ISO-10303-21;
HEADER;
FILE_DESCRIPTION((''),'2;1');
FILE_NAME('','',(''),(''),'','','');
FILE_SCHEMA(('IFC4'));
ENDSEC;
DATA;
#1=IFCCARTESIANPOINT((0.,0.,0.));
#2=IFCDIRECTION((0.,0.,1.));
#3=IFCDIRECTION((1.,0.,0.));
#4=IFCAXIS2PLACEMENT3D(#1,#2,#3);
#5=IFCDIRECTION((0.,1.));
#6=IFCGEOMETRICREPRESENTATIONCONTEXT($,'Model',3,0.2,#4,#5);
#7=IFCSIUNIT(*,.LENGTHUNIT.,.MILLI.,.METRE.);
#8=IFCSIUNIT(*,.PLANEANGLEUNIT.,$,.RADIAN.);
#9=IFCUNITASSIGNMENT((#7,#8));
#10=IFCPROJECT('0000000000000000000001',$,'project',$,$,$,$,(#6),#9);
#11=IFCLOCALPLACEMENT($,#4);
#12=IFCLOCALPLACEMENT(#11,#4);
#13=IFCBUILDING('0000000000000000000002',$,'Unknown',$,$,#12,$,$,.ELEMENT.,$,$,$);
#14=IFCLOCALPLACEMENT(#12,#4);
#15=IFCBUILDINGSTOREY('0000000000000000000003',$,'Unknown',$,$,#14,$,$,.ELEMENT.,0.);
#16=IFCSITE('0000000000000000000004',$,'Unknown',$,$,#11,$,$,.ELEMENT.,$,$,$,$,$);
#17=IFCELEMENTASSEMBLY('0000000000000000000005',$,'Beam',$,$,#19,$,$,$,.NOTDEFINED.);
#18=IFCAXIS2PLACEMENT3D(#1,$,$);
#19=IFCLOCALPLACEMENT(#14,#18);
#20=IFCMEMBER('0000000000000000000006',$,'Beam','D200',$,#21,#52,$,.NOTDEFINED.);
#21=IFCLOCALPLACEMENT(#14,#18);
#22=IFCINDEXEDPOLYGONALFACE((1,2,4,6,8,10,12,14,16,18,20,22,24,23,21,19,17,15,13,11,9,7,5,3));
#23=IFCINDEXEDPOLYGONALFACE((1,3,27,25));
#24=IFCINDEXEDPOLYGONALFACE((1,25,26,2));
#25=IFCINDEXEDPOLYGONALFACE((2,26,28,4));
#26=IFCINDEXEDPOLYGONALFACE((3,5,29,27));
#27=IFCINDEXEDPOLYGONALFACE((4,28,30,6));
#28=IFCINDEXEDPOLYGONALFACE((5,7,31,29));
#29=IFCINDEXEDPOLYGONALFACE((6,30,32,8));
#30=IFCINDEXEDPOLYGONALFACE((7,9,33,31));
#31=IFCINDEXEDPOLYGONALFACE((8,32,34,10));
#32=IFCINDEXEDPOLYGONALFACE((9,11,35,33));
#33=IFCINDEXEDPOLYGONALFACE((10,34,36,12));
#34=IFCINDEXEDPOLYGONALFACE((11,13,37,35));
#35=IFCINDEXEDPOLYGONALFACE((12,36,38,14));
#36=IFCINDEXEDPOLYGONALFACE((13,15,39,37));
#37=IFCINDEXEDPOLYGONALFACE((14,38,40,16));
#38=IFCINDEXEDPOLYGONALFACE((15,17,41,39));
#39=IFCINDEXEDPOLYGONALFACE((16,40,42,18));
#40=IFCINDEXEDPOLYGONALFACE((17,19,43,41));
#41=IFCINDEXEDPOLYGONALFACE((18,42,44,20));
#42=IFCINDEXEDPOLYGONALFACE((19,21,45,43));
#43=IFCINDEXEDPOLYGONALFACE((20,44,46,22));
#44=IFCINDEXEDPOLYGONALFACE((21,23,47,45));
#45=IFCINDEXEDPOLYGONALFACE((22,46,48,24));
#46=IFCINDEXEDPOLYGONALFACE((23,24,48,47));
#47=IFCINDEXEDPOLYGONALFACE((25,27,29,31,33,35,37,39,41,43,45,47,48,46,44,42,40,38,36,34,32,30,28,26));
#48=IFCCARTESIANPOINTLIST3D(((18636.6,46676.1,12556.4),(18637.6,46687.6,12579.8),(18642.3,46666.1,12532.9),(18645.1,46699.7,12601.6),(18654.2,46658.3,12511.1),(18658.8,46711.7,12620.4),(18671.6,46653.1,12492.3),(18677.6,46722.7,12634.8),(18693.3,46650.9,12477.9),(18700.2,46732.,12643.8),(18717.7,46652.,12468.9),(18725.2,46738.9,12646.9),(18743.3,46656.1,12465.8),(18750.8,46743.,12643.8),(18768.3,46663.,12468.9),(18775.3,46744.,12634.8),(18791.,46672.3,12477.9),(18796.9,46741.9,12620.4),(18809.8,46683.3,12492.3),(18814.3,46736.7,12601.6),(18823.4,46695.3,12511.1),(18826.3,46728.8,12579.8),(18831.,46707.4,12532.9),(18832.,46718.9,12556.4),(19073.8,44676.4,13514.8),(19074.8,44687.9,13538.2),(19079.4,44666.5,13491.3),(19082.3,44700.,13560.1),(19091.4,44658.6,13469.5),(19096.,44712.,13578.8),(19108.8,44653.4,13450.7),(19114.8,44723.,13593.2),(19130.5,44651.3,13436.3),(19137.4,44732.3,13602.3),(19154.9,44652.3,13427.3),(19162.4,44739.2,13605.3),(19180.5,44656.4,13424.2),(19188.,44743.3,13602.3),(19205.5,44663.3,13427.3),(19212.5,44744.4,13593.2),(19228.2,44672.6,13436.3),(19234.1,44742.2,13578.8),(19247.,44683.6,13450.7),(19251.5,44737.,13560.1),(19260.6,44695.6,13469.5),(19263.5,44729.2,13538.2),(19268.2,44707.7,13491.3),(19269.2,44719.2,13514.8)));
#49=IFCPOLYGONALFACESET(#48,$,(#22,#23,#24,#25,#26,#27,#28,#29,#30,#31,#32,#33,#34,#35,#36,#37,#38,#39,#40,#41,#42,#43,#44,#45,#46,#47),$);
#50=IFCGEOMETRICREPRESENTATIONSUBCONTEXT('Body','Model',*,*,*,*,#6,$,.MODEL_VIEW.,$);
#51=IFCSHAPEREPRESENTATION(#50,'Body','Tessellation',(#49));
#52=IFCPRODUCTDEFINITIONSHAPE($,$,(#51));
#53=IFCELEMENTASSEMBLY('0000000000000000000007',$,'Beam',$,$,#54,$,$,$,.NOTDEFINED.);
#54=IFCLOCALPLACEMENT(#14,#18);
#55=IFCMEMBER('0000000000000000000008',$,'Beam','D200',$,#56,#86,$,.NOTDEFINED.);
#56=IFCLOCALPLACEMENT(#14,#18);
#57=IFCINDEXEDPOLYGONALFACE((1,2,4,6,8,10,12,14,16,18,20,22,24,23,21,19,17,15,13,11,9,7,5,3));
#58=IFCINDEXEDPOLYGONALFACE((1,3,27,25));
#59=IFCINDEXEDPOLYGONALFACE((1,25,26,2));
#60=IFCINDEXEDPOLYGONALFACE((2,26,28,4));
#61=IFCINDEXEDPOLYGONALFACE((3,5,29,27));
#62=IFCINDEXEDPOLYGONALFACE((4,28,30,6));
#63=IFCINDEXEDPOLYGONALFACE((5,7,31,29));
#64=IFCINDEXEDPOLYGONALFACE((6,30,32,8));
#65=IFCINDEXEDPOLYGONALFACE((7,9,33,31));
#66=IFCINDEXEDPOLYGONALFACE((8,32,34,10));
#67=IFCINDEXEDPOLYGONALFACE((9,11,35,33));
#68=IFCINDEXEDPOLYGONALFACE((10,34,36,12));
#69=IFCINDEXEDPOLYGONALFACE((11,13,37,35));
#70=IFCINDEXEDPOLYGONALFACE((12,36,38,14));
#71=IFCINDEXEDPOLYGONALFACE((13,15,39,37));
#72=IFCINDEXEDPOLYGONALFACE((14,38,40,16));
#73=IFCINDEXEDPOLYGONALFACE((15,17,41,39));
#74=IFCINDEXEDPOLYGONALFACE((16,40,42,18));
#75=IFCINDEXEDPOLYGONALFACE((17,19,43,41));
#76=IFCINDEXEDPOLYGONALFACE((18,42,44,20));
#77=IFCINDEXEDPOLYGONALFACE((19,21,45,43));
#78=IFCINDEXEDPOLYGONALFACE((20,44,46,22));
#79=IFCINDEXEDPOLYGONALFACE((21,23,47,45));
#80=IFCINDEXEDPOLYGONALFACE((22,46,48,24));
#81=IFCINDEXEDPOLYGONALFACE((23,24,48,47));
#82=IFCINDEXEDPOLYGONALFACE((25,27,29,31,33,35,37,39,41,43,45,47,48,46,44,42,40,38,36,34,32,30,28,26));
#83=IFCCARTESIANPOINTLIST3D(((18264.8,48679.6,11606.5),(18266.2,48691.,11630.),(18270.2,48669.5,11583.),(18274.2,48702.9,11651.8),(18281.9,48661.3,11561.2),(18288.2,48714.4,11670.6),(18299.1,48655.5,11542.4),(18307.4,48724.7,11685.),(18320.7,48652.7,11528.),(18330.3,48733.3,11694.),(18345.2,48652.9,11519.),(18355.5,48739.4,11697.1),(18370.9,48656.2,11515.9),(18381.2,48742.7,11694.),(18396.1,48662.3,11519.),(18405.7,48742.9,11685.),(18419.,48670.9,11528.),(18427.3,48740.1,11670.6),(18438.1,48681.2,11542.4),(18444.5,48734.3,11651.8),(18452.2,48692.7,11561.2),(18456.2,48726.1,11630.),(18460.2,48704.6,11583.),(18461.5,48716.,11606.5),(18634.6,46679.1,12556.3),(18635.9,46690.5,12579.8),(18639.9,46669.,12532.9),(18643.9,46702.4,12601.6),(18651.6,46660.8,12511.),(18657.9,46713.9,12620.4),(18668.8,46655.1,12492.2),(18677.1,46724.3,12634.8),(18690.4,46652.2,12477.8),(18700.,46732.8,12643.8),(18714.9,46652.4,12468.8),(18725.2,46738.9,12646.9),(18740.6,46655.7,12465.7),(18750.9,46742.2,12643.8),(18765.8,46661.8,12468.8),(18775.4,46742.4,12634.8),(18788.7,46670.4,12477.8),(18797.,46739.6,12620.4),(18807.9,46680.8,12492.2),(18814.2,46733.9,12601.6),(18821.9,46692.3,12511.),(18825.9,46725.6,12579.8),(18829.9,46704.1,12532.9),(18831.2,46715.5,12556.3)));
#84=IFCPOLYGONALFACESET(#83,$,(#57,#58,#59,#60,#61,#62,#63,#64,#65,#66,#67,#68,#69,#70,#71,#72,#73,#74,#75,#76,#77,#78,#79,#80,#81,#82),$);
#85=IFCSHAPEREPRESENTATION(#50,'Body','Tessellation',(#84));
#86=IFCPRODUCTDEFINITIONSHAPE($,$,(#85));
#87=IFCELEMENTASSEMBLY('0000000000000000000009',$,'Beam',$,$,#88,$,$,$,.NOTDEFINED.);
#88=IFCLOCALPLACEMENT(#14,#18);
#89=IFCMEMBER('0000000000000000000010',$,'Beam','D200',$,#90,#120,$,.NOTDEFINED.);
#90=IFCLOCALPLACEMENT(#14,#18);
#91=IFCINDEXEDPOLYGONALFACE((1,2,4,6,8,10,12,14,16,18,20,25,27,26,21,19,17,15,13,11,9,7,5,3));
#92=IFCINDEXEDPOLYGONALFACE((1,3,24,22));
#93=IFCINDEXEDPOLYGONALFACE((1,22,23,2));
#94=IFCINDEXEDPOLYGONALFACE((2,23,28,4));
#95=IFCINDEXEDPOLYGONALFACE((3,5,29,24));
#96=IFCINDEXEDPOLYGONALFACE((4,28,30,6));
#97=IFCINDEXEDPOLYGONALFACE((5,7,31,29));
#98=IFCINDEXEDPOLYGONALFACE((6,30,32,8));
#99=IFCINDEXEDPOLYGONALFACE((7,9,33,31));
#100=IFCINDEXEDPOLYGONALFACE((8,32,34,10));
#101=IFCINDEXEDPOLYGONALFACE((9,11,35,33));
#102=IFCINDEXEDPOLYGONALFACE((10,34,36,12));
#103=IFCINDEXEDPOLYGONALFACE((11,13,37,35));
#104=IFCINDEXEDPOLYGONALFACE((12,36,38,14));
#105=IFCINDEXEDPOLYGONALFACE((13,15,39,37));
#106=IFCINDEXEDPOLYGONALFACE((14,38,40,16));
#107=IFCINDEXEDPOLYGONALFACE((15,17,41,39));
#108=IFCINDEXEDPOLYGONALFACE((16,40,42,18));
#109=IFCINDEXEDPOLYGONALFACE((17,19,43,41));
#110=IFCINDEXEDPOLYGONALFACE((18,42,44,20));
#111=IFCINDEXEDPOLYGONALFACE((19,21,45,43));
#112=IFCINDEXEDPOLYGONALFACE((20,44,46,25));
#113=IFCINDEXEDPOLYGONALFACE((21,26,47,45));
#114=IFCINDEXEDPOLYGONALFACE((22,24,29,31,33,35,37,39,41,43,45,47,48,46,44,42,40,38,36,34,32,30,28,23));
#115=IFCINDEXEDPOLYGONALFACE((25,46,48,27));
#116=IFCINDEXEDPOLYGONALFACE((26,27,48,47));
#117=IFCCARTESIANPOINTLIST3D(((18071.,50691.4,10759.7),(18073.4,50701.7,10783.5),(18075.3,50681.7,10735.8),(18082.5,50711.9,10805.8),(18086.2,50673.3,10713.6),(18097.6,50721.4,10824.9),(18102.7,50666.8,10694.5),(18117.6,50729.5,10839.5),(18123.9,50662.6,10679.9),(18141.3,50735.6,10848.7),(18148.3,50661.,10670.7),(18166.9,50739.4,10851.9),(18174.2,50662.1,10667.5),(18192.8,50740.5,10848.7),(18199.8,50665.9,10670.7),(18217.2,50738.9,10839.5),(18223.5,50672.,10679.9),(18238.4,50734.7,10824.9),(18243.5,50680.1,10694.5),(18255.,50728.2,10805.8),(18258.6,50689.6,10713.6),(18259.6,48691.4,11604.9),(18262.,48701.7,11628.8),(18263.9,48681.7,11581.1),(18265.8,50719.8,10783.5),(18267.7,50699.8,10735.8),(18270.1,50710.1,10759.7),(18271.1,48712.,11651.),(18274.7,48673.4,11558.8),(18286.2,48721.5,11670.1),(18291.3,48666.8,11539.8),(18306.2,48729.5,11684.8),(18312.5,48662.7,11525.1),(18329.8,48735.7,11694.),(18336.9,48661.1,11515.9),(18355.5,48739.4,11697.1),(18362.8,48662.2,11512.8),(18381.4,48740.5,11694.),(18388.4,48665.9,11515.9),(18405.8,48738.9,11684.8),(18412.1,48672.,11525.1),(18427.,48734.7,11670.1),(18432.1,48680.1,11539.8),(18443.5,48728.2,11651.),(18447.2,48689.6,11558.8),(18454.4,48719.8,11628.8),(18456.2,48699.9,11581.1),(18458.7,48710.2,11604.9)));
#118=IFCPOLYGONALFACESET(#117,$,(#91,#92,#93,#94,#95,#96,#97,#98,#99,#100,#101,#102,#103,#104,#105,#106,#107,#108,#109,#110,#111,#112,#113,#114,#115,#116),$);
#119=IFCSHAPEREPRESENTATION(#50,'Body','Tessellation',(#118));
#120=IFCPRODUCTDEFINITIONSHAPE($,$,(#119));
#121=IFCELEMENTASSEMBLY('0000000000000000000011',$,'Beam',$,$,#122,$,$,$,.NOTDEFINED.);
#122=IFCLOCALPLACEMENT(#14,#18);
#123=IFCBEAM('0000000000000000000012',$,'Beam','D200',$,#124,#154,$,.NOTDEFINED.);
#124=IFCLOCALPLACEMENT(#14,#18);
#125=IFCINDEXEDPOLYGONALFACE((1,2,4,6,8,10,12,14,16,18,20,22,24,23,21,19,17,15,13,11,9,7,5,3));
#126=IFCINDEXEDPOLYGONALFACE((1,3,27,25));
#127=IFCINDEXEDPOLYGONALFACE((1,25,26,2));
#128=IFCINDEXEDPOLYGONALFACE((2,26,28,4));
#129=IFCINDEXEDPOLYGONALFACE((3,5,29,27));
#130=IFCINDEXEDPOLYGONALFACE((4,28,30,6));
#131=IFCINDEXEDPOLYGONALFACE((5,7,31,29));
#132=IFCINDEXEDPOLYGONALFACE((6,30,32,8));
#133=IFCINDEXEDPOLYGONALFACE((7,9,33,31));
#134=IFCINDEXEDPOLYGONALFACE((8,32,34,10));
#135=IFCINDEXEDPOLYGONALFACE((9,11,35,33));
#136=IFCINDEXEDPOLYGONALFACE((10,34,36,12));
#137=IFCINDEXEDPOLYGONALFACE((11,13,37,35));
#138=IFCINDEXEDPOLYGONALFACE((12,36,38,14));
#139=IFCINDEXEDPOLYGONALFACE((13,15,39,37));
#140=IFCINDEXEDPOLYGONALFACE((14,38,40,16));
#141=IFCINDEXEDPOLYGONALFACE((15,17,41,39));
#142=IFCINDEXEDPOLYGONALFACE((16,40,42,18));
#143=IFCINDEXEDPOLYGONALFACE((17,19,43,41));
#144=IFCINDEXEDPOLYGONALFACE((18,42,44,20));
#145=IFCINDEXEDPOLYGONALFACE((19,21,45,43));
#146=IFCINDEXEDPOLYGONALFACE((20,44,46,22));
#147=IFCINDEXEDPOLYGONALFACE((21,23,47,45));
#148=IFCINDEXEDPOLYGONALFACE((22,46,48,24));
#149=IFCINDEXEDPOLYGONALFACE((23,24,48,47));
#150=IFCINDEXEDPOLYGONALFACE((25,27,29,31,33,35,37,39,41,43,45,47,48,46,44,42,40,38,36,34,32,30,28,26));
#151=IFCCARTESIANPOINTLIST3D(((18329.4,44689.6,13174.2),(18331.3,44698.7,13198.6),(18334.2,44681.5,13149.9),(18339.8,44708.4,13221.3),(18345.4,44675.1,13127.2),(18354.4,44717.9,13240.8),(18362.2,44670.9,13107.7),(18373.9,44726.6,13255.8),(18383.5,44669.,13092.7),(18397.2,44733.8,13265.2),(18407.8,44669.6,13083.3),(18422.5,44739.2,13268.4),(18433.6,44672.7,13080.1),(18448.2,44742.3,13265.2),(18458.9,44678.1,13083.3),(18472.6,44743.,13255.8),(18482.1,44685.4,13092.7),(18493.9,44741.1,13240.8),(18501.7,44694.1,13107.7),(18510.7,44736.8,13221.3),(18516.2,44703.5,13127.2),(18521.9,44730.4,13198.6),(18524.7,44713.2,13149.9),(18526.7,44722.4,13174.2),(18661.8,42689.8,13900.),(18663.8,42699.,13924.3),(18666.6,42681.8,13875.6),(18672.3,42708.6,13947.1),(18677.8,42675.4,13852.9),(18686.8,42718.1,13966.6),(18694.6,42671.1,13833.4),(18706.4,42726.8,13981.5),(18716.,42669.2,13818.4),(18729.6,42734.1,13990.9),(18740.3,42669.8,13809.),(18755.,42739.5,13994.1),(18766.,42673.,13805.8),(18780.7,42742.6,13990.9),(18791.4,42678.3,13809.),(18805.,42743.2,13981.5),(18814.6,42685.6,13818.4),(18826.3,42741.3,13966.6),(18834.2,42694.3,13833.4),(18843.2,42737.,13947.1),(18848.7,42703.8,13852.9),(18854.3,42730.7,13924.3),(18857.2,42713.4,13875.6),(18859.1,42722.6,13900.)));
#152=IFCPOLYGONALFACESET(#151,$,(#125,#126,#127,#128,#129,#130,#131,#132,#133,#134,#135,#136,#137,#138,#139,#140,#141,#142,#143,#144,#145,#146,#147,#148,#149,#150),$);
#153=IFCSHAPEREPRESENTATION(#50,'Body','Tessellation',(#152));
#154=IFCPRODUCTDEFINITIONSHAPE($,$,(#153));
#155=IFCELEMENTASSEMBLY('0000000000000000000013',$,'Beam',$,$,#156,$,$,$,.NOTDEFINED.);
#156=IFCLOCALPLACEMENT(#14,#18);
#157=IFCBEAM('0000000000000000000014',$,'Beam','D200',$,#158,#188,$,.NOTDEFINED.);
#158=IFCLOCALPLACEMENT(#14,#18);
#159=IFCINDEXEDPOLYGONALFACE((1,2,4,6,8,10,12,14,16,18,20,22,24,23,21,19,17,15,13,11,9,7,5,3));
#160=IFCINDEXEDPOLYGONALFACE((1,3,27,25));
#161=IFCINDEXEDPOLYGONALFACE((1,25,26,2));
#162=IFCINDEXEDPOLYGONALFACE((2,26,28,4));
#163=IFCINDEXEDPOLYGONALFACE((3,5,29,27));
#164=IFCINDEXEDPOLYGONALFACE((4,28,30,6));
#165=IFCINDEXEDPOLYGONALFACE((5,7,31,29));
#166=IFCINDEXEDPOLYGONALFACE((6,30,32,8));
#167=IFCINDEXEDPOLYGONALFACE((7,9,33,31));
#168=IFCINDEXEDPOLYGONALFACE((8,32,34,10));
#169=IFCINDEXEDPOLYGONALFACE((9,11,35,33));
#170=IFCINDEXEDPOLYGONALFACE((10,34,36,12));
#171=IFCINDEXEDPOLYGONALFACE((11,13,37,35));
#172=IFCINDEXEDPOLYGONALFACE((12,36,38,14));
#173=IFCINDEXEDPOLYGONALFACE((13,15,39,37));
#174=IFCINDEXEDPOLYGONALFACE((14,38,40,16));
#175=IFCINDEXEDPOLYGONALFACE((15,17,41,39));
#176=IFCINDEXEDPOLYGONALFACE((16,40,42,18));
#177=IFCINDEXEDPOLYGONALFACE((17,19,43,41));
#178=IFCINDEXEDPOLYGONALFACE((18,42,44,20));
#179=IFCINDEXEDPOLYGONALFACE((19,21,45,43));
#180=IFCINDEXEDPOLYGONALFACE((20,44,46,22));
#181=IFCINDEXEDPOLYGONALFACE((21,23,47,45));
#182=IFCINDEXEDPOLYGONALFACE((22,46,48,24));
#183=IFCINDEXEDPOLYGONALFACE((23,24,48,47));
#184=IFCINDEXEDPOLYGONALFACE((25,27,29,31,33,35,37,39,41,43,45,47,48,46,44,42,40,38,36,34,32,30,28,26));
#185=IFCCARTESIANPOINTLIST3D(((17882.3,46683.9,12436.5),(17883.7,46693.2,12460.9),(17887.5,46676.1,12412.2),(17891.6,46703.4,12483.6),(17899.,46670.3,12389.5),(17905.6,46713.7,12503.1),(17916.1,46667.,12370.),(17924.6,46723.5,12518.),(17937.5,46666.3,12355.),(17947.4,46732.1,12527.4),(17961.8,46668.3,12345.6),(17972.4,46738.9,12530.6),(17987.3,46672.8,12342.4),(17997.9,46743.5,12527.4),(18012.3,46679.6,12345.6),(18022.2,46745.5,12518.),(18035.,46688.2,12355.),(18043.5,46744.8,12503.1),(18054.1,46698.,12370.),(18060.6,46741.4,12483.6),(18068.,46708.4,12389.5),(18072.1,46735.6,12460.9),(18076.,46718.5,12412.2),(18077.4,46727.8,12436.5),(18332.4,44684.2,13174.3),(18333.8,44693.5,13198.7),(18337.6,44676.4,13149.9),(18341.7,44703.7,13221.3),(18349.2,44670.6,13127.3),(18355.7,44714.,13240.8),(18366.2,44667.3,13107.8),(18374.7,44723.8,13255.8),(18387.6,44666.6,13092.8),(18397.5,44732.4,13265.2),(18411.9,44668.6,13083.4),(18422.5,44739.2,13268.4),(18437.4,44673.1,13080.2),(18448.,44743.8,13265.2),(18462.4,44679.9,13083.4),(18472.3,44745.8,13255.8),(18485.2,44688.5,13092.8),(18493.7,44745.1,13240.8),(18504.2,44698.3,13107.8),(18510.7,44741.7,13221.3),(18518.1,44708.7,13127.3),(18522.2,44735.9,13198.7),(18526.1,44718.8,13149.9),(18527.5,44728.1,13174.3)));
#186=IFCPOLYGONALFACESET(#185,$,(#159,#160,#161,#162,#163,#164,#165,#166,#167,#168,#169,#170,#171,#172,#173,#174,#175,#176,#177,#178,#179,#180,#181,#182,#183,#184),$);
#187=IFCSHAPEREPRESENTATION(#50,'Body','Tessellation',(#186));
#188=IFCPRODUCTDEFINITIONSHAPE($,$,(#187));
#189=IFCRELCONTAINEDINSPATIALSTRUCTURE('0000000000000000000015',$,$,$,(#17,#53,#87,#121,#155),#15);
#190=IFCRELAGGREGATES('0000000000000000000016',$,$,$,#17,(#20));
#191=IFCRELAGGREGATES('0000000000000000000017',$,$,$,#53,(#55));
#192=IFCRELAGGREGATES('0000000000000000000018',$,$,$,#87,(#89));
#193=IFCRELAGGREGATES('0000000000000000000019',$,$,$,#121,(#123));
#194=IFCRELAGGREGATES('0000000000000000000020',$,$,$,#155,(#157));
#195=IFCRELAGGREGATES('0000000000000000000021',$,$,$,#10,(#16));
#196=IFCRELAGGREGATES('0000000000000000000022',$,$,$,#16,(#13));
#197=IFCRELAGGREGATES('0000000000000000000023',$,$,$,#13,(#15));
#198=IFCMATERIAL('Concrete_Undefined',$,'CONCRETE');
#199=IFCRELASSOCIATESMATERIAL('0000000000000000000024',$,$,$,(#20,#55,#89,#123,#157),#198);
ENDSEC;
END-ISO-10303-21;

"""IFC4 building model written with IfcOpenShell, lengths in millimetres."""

from ifc_helpers import new_model, si_unit, direction, frame, origin_with_axes, place, context, subcontext, project, spatial, line, indexed_curve, outline, extrude, material, element, aggregate, save


model = new_model("IFC4")

# Units and contexts
model_context = context("Model", 3, precision=0.2, world=origin_with_axes(), true_north=direction((0.0, 1.0)))
body_context = subcontext(model_context, "Body", "Model", "MODEL_VIEW")
ifc_project = project(units=[si_unit("LENGTHUNIT", "METRE", prefix="MILLI"), si_unit("PLANEANGLEUNIT", "RADIAN")], contexts=[model_context])

# Site, building, storey
site_placement = place(None, origin_with_axes())
site = spatial("IfcSite", under=ifc_project, at=site_placement, Name="Unknown", CompositionType="ELEMENT")
building_placement = place(site_placement, origin_with_axes())
building = spatial("IfcBuilding", under=site, at=building_placement, Name="Unknown", CompositionType="ELEMENT")
storey_placement = place(building_placement, origin_with_axes())
storey = spatial("IfcBuildingStorey", under=building, at=storey_placement, Name="Unknown", CompositionType="ELEMENT", Elevation=0.0)

# Shared definitions
ifc_material = material(Name="Concrete_Undefined", Category="CONCRETE")

# Element assemblies, members
assembly_1_placement = place(storey_placement, frame((18734.3, 46697.5, 12556.4), z_axis=(-0.976924, -0.213586, 0.0), x_axis=(0.193433, -0.884744, 0.424042)))
assembly_1 = element("IfcElementAssembly", 1, at=assembly_1_placement, inside=storey, Name="Beam", PredefinedType="NOTDEFINED")
member_1_placement = place(assembly_1_placement, origin_with_axes())
member_1 = element("IfcMember", 2, at=member_1_placement, material=ifc_material, Name="Beam", Description="D200", PredefinedType="NOTDEFINED", context=body_context, shape_type="SolidModel", body=[
    extrude(outline(indexed_curve([(100.0, 0.0), (96.6, 25.9), (86.6, 50.0), (70.7, 70.7), (50.0, 86.6), (25.9, 96.6), (0.0, 100.0), (-25.9, 96.6), (-50.0, 86.6), (-70.7, 70.7), (-86.6, 50.0), (-96.6, 25.9), (-100.0, 0.0), (-96.6, -25.9), (-86.6, -50.0), (-70.7, -70.7), (-50.0, -86.6), (-25.9, -96.6), (0.0, -100.0), (25.9, -96.6), (50.0, -86.6), (70.7, -70.7), (86.6, -50.0), (96.6, -25.9)], segments=[line(1, 2, 3, 4, 5, 6, 7, 8, 9, 10, 11, 12, 13, 14, 15, 16, 17, 18, 19, 20, 21, 22, 23, 24, 1)])), frame((0.0, 0.0, 0.0), z_axis=(-1.0, 0.0, 0.0), x_axis=(0.0, 0.0, 1.0)), (0.0, 0.0, -1.0), 2260.2),
])
aggregate(assembly_1, [member_1])
assembly_2_placement = place(storey_placement, frame((18363.2, 48697.8, 11606.5), z_axis=(-0.983346, -0.181742, 0.0), x_axis=(0.164677, -0.891016, 0.423052)))
assembly_2 = element("IfcElementAssembly", 3, at=assembly_2_placement, inside=storey, Name="Beam", PredefinedType="NOTDEFINED")
member_2_placement = place(assembly_2_placement, origin_with_axes())
member_2 = element("IfcMember", 4, at=member_2_placement, material=ifc_material, Name="Beam", Description="D200", PredefinedType="NOTDEFINED", context=body_context, shape_type="SolidModel", body=[
    extrude(outline(indexed_curve([(100.0, 0.0), (96.6, 25.9), (86.6, 50.0), (70.7, 70.7), (50.0, 86.6), (25.9, 96.6), (0.0, 100.0), (-25.9, 96.6), (-50.0, 86.6), (-70.7, 70.7), (-86.6, 50.0), (-96.6, 25.9), (-100.0, 0.0), (-96.6, -25.9), (-86.6, -50.0), (-70.7, -70.7), (-50.0, -86.6), (-25.9, -96.6), (0.0, -100.0), (25.9, -96.6), (50.0, -86.6), (70.7, -70.7), (86.6, -50.0), (96.6, -25.9)], segments=[line(1, 2, 3, 4, 5, 6, 7, 8, 9, 10, 11, 12, 13, 14, 15, 16, 17, 18, 19, 20, 21, 22, 23, 24, 1)])), frame((0.0, 0.0, 0.0), z_axis=(-1.0, 0.0, 0.0), x_axis=(0.0, 0.0, 1.0)), (0.0, 0.0, -1.0), 2245.2),
])
aggregate(assembly_2, [member_2])
assembly_3_placement = place(storey_placement, frame((18170.6, 50700.8, 10759.7), z_axis=(-0.995584, -0.093871, 0.0), x_axis=(0.086523, -0.91766, 0.387831)))
assembly_3 = element("IfcElementAssembly", 5, at=assembly_3_placement, inside=storey, Name="Beam", PredefinedType="NOTDEFINED")
member_3_placement = place(assembly_3_placement, origin_with_axes())
member_3 = element("IfcMember", 6, at=member_3_placement, material=ifc_material, Name="Beam", Description="D200", PredefinedType="NOTDEFINED", context=body_context, shape_type="SolidModel", body=[
    extrude(outline(indexed_curve([(100.0, 0.0), (96.6, 25.9), (86.6, 50.0), (70.7, 70.7), (50.0, 86.6), (25.9, 96.6), (0.0, 100.0), (-25.9, 96.6), (-50.0, 86.6), (-70.7, 70.7), (-86.6, 50.0), (-96.6, 25.9), (-100.0, 0.0), (-96.6, -25.9), (-86.6, -50.0), (-70.7, -70.7), (-50.0, -86.6), (-25.9, -96.6), (0.0, -100.0), (25.9, -96.6), (50.0, -86.6), (70.7, -70.7), (86.6, -50.0), (96.6, -25.9)], segments=[line(1, 2, 3, 4, 5, 6, 7, 8, 9, 10, 11, 12, 13, 14, 15, 16, 17, 18, 19, 20, 21, 22, 23, 24, 1)])), frame((0.0, 0.0, 0.0), z_axis=(-1.0, 0.0, 0.0), x_axis=(0.0, 0.0, 1.0)), (0.0, 0.0, -1.0), 2179.4),
])
aggregate(assembly_3, [member_3])

# Element assemblies, beams
assembly_4_placement = place(storey_placement, frame((18428.0, 44706.0, 13174.2), z_axis=(-0.98646, -0.164002, 0.0), x_axis=(0.154406, -0.928739, 0.33705)))
assembly_4 = element("IfcElementAssembly", 7, at=assembly_4_placement, inside=storey, Name="Beam", PredefinedType="NOTDEFINED")
beam_1_placement = place(assembly_4_placement, origin_with_axes())
beam_1 = element("IfcBeam", 8, at=beam_1_placement, material=ifc_material, Name="Beam", Description="D200", PredefinedType="NOTDEFINED", context=body_context, shape_type="SolidModel", body=[
    extrude(outline(indexed_curve([(100.0, 0.0), (96.6, 25.9), (86.6, 50.0), (70.7, 70.7), (50.0, 86.6), (25.9, 96.6), (0.0, 100.0), (-25.9, 96.6), (-50.0, 86.6), (-70.7, 70.7), (-86.6, 50.0), (-96.6, 25.9), (-100.0, 0.0), (-96.6, -25.9), (-86.6, -50.0), (-70.7, -70.7), (-50.0, -86.6), (-25.9, -96.6), (0.0, -100.0), (25.9, -96.6), (50.0, -86.6), (70.7, -70.7), (86.6, -50.0), (96.6, -25.9)], segments=[line(1, 2, 3, 4, 5, 6, 7, 8, 9, 10, 11, 12, 13, 14, 15, 16, 17, 18, 19, 20, 21, 22, 23, 24, 1)])), frame((0.0, 0.0, 0.0), z_axis=(-1.0, 0.0, 0.0), x_axis=(0.0, 0.0, 1.0)), (0.0, 0.0, -1.0), 2153.2),
])
aggregate(assembly_4, [beam_1])
assembly_5_placement = place(storey_placement, frame((17979.8, 46705.9, 12436.5), z_axis=(-0.97559, -0.219598, 0.0), x_axis=(0.206621, -0.91794, 0.338666)))
assembly_5 = element("IfcElementAssembly", 9, at=assembly_5_placement, inside=storey, Name="Beam", PredefinedType="NOTDEFINED")
beam_2_placement = place(assembly_5_placement, origin_with_axes())
beam_2 = element("IfcBeam", 10, at=beam_2_placement, material=ifc_material, Name="Beam", Description="D200", PredefinedType="NOTDEFINED", context=body_context, shape_type="SolidModel", body=[
    extrude(outline(indexed_curve([(100.0, 0.0), (96.6, 25.9), (86.6, 50.0), (70.7, 70.7), (50.0, 86.6), (25.9, 96.6), (0.0, 100.0), (-25.9, 96.6), (-50.0, 86.6), (-70.7, 70.7), (-86.6, 50.0), (-96.6, 25.9), (-100.0, 0.0), (-96.6, -25.9), (-86.6, -50.0), (-70.7, -70.7), (-50.0, -86.6), (-25.9, -96.6), (0.0, -100.0), (25.9, -96.6), (50.0, -86.6), (70.7, -70.7), (86.6, -50.0), (96.6, -25.9)], segments=[line(1, 2, 3, 4, 5, 6, 7, 8, 9, 10, 11, 12, 13, 14, 15, 16, 17, 18, 19, 20, 21, 22, 23, 24, 1)])), frame((0.0, 0.0, 0.0), z_axis=(-1.0, 0.0, 0.0), x_axis=(0.0, 0.0, 1.0)), (0.0, 0.0, -1.0), 2178.5),
])
aggregate(assembly_5, [beam_2])

save(model, "model.ifc")
